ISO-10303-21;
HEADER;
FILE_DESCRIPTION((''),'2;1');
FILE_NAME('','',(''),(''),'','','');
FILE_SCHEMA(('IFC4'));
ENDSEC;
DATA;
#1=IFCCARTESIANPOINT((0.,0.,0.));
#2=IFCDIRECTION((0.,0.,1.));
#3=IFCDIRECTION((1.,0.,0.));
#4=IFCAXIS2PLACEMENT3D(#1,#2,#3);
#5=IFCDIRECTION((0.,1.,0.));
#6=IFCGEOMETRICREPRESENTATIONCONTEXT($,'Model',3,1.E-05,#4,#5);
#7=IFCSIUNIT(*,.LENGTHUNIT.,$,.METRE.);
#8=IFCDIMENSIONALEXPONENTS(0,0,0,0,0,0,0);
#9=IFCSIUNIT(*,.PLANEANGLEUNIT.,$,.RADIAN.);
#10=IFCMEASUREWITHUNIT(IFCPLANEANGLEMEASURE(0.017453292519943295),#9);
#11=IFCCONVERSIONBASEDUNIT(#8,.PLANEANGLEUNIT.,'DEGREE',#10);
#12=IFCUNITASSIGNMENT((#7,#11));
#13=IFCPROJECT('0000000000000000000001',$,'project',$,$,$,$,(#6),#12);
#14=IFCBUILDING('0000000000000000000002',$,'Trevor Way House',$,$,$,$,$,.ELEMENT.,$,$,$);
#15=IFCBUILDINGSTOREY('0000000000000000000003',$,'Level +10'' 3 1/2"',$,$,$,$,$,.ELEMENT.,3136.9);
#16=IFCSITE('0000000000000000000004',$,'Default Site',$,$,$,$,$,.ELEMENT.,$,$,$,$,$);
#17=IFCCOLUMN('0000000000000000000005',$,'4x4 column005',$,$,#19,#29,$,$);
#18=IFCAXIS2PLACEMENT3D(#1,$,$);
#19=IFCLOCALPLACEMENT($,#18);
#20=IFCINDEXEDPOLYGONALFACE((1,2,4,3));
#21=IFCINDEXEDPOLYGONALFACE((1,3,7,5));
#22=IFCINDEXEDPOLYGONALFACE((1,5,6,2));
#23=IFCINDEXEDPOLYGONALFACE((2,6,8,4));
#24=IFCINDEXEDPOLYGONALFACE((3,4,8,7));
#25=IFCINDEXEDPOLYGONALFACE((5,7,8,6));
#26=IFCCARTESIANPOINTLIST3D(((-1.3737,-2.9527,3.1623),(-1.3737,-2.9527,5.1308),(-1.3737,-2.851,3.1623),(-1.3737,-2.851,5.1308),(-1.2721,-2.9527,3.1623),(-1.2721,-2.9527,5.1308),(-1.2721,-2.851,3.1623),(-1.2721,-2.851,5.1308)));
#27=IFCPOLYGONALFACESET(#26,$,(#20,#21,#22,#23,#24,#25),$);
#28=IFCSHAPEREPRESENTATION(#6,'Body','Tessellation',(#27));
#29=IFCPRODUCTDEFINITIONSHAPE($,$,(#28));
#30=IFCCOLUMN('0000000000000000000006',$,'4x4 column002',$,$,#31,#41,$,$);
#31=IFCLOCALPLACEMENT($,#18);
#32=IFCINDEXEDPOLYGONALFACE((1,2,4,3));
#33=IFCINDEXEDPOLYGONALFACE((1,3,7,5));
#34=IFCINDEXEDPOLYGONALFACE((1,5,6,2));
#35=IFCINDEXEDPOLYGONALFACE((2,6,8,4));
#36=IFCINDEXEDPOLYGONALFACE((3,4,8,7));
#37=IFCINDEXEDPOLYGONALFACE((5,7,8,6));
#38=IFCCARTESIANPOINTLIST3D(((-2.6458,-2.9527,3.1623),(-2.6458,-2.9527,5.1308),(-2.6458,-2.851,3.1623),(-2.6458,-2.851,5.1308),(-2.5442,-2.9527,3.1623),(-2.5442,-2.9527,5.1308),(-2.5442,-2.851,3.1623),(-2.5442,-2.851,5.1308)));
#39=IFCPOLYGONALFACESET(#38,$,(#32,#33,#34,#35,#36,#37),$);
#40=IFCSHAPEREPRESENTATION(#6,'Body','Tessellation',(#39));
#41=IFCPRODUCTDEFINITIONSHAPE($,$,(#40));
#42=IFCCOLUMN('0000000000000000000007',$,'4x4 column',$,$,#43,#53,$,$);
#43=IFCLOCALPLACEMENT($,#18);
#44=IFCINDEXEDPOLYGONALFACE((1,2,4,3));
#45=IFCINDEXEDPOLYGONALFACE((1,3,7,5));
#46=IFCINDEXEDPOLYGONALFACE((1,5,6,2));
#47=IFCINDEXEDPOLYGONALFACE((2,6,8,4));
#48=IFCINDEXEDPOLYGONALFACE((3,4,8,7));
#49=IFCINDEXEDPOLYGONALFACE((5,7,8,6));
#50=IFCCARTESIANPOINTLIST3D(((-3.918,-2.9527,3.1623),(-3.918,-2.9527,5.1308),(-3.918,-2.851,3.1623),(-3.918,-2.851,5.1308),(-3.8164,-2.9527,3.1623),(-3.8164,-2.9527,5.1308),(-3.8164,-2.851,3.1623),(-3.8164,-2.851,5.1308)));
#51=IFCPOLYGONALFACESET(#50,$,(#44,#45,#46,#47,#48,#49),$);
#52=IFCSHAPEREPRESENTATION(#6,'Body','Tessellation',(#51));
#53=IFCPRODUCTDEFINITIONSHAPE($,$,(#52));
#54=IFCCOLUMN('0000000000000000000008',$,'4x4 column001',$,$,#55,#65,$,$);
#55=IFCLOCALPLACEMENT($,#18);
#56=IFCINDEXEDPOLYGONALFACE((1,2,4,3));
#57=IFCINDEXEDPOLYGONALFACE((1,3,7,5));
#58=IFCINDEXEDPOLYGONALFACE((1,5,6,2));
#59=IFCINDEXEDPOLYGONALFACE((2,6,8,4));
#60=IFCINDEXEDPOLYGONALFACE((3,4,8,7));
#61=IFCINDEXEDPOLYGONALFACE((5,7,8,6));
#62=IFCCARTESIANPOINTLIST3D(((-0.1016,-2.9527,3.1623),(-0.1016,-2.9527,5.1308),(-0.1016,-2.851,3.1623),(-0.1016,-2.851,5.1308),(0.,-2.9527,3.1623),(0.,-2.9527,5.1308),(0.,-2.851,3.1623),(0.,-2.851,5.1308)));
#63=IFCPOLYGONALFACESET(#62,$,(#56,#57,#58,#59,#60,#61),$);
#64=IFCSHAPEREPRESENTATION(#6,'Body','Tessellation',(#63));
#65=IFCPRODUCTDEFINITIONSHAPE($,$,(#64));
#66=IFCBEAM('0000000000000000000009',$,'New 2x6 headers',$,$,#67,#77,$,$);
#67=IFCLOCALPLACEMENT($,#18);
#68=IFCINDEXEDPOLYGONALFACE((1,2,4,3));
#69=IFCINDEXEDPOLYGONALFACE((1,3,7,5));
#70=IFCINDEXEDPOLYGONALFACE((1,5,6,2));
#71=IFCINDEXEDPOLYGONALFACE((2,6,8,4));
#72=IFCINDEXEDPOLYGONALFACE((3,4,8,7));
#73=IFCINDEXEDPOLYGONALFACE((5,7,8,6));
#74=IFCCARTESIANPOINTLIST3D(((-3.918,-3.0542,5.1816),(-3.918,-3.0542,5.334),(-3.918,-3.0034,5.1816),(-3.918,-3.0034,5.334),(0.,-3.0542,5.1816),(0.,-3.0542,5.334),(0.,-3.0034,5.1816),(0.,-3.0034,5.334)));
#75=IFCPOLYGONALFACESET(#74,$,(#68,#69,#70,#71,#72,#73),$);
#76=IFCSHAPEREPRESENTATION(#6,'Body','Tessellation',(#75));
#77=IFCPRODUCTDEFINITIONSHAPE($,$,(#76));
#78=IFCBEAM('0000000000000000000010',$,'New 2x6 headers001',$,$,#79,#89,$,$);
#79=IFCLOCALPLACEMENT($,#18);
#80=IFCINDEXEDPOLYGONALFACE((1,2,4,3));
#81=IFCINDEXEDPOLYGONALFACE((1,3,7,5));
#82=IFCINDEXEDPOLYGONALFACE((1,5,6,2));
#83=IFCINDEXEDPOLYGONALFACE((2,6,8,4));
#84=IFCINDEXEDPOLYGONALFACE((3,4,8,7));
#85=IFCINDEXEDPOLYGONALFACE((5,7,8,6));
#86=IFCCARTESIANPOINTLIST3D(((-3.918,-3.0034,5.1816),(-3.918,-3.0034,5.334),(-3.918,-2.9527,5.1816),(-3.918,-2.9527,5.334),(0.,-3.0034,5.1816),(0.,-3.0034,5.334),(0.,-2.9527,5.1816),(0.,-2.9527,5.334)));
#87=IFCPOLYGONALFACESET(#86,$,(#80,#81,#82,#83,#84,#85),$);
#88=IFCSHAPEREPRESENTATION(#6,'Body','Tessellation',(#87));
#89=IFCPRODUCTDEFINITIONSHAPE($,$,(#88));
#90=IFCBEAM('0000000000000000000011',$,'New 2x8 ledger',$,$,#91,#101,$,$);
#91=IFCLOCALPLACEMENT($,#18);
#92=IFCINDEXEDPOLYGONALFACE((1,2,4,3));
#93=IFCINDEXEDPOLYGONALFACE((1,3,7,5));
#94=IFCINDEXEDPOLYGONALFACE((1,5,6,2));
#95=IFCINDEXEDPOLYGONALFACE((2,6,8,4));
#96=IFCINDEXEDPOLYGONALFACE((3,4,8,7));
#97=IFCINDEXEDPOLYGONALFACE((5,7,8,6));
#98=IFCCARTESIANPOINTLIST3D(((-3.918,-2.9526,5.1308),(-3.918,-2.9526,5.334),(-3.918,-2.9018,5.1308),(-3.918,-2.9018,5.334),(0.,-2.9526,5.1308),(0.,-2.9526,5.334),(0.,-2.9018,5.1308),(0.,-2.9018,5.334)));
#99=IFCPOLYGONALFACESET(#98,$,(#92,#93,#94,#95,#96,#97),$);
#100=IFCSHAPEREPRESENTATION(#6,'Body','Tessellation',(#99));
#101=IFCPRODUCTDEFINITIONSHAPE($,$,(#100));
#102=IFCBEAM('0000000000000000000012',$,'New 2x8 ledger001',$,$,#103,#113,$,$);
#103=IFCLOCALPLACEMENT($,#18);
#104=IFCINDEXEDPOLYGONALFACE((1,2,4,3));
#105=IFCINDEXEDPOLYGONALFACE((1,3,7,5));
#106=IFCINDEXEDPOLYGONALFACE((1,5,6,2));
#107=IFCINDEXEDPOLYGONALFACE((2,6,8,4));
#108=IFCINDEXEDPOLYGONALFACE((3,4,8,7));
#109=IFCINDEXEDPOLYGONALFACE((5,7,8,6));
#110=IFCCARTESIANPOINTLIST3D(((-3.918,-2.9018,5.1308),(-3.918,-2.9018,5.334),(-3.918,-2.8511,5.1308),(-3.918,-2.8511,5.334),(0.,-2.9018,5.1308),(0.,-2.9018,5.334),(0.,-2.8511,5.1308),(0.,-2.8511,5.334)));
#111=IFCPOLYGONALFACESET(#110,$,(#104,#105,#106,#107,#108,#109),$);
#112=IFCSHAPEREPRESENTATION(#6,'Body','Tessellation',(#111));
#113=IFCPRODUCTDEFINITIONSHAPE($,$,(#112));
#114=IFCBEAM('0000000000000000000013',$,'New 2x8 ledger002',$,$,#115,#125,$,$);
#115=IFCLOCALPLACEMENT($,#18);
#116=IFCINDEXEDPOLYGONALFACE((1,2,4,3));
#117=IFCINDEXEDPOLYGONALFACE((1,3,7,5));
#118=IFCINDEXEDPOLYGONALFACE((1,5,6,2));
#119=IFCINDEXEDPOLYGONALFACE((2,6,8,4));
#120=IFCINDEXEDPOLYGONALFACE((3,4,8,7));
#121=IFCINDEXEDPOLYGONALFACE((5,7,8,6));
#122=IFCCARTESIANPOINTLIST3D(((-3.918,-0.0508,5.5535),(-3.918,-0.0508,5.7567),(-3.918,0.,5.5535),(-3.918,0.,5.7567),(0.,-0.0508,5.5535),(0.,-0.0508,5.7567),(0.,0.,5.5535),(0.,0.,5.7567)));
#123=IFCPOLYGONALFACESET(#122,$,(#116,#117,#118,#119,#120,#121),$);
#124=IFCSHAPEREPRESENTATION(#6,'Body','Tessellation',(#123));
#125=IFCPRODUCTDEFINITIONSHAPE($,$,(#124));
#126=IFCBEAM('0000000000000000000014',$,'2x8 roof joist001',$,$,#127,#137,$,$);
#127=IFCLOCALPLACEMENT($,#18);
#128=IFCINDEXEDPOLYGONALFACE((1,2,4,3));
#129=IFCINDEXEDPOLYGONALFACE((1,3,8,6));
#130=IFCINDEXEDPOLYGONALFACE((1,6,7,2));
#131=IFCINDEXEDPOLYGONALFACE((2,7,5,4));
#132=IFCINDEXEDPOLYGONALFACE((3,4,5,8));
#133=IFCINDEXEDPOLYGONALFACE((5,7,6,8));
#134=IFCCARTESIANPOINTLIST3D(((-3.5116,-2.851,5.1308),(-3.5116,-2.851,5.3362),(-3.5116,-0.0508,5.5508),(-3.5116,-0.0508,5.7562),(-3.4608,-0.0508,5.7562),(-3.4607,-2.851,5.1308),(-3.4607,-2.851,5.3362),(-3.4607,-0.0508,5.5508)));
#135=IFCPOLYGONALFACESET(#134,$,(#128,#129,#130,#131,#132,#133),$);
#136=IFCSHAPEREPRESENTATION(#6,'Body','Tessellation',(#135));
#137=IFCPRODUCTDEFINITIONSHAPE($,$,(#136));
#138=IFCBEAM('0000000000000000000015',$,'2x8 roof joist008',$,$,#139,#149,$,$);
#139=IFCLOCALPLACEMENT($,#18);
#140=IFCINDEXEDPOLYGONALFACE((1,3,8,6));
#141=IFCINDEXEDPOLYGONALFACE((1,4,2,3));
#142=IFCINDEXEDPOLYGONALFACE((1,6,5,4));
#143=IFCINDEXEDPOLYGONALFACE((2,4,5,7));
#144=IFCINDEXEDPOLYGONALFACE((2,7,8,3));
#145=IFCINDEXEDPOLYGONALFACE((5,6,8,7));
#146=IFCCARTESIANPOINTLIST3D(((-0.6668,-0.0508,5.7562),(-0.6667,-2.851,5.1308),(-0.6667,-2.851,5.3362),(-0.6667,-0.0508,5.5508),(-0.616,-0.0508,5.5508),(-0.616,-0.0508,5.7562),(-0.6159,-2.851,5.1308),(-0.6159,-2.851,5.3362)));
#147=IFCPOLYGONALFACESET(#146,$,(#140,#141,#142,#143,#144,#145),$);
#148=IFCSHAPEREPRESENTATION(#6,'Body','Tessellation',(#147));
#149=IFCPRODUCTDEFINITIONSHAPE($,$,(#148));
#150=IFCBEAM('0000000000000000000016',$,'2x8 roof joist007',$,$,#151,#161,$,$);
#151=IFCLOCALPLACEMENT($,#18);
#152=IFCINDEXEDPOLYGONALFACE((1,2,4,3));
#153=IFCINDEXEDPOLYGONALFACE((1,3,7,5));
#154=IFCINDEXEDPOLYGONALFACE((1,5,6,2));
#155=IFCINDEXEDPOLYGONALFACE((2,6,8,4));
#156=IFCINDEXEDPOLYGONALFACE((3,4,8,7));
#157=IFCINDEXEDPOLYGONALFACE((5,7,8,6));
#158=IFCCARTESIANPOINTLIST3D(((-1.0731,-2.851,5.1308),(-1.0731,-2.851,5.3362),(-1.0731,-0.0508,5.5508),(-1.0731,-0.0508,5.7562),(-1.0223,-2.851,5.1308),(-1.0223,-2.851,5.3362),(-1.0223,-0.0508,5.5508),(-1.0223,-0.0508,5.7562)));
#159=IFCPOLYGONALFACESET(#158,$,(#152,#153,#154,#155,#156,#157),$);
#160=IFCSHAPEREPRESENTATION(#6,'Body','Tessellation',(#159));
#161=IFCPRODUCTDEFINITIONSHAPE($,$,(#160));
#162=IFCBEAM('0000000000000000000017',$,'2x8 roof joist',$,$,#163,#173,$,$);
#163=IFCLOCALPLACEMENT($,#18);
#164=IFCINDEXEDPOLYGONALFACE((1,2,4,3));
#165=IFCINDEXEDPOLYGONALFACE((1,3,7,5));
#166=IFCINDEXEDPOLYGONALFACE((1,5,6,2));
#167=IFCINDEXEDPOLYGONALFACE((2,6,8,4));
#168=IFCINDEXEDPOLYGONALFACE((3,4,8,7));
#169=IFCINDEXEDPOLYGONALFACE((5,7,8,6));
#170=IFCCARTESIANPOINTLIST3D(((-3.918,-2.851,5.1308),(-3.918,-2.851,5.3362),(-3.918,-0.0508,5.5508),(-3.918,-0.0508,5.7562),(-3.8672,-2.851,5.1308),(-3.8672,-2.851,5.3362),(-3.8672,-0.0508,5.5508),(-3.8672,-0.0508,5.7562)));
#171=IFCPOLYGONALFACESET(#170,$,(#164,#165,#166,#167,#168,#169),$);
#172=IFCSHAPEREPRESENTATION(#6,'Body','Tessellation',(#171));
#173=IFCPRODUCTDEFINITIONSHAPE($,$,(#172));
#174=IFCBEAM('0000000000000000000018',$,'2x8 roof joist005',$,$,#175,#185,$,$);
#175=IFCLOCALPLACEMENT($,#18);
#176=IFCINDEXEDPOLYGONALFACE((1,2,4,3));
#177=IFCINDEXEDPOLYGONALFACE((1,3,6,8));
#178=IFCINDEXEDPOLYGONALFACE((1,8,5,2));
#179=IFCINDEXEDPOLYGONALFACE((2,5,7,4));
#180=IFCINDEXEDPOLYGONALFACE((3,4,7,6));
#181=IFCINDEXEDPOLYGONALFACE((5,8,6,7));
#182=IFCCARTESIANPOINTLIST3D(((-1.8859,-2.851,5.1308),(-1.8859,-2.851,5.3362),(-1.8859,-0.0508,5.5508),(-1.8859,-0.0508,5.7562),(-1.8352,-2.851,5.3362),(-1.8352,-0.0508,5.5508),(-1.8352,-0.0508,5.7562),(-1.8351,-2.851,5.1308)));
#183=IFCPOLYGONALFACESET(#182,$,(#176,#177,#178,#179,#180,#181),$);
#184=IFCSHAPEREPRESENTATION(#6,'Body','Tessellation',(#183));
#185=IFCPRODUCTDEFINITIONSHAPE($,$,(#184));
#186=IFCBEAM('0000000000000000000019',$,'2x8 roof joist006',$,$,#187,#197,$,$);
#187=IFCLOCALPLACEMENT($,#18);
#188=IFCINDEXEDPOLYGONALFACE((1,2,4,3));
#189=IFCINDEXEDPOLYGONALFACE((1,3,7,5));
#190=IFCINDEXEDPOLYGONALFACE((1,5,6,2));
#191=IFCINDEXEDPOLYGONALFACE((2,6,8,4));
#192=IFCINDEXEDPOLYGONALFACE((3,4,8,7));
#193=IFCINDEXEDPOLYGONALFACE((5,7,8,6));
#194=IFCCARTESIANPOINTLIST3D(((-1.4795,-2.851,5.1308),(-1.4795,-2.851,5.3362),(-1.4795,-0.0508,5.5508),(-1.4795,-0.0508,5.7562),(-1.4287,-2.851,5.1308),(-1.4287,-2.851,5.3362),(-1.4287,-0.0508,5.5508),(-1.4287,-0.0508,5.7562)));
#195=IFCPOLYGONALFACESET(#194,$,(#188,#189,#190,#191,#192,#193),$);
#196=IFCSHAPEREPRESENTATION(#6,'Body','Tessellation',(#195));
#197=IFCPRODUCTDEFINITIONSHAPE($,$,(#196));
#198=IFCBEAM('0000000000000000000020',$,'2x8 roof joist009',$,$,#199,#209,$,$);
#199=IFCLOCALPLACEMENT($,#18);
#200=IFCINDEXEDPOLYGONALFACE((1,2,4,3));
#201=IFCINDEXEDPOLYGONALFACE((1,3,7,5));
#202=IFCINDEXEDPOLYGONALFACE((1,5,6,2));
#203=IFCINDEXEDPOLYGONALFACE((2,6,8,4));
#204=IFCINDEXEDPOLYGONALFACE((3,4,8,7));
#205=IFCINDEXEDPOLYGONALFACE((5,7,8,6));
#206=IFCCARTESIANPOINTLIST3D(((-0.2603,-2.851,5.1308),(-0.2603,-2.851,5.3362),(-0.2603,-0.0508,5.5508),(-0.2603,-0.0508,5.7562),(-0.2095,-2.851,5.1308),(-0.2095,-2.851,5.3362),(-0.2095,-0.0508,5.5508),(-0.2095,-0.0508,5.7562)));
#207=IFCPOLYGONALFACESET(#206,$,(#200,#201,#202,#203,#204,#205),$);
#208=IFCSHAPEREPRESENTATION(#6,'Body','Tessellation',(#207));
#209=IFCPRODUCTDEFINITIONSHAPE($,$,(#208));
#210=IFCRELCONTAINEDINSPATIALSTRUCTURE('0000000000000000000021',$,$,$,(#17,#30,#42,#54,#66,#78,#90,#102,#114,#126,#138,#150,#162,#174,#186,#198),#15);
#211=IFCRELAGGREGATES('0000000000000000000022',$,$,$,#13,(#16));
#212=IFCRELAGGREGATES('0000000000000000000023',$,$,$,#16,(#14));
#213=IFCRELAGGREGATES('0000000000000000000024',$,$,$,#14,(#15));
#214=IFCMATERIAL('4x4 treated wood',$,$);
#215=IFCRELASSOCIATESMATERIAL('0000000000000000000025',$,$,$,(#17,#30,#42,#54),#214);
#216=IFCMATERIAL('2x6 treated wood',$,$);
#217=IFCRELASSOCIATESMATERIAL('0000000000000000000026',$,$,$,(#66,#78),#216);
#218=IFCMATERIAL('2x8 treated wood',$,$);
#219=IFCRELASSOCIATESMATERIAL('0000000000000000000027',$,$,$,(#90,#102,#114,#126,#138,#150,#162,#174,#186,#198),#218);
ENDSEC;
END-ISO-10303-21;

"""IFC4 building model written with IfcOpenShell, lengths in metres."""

from ifc_helpers import new_model, entity, si_unit, converted_unit, direction, frame, origin_with_axes, place, context, project, spatial, polyline, outline, extrude, source, transform, mapped, material, element, save


model = new_model("IFC4")

# Units and contexts
model_context = context("Model", 3, precision=1e-05, world=origin_with_axes(), true_north=direction((0.0, 1.0, 0.0)))
ifc_project = project(units=[si_unit("LENGTHUNIT", "METRE"), converted_unit("PLANEANGLEUNIT", "DEGREE", entity("IfcPlaneAngleMeasure", 0.017453292519943295), si_unit("PLANEANGLEUNIT", "RADIAN"), dimensions=[0, 0, 0, 0, 0, 0, 0])], contexts=[model_context])

# Site, building, storey
site = spatial("IfcSite", under=ifc_project, Name="Default Site", CompositionType="ELEMENT")
building = spatial("IfcBuilding", under=site, Name="Trevor Way House", CompositionType="ELEMENT")
storey = spatial("IfcBuildingStorey", under=building, Name="Level +10' 3 1/2\"", CompositionType="ELEMENT", Elevation=3136.9)

# Columns
ifc_material_1 = material(Name="4x4 treated wood")
shared_shape_1 = source(origin_with_axes(), model_context, "Body", "SweptSolid", [
    extrude(outline(polyline([(-0.0508, -0.0508), (0.0508, -0.0508), (0.0508, 0.0508), (-0.0508, 0.0508), (-0.0508, -0.0508)])), frame((0.0, 0.0, 0.0), z_axis=(0.0, 0.0, 1.0), x_axis=(1.0, 0.0, 0.0)), (0.0, 0.0, 1.0), 1.9685),
])
placement = place(None, origin_with_axes())
element("IfcColumn", 1, at=placement, inside=storey, material=ifc_material_1, Name="4x4 column005", context=model_context, shape_type="MappedRepresentation", body=[
    mapped(shared_shape_1, transform((-1.3229, -2.9019, 3.1623), x_axis=(1.0, 0.0, 0.0), y_axis=(0.0, 1.0, 0.0), z_axis=(0.0, 0.0, 1.0), scale=1.0)),
])
element("IfcColumn", 2, at=placement, inside=storey, material=ifc_material_1, Name="4x4 column002", context=model_context, shape_type="MappedRepresentation", body=[
    mapped(shared_shape_1, transform((-2.595, -2.9019, 3.1623), x_axis=(1.0, 0.0, 0.0), y_axis=(0.0, 1.0, 0.0), z_axis=(0.0, 0.0, 1.0), scale=1.0)),
])
element("IfcColumn", 3, at=placement, inside=storey, material=ifc_material_1, Name="4x4 column", context=model_context, shape_type="MappedRepresentation", body=[
    mapped(shared_shape_1, transform((-3.8672, -2.9019, 3.1623), x_axis=(1.0, 0.0, 0.0), y_axis=(0.0, 1.0, 0.0), z_axis=(0.0, 0.0, 1.0), scale=1.0)),
])
element("IfcColumn", 4, at=placement, inside=storey, material=ifc_material_1, Name="4x4 column001", context=model_context, shape_type="MappedRepresentation", body=[
    mapped(shared_shape_1, transform((-0.0508, -2.9019, 3.1623), x_axis=(1.0, 0.0, 0.0), y_axis=(0.0, 1.0, 0.0), z_axis=(0.0, 0.0, 1.0), scale=1.0)),
])

# Beams
ifc_material_2 = material(Name="2x6 treated wood")
shared_shape_2 = source(origin_with_axes(), model_context, "Body", "SweptSolid", [
    extrude(outline(polyline([(-0.0254, -0.0762), (0.0254, -0.0762), (0.0254, 0.0762), (-0.0254, 0.0762), (-0.0254, -0.0762)])), frame((0.0, 0.0, 0.0), z_axis=(0.0, 0.0, 1.0), x_axis=(1.0, 0.0, 0.0)), (0.0, 0.0, 1.0), 3.9179),
])
element("IfcBeam", 5, at=placement, inside=storey, material=ifc_material_2, Name="New 2x6 headers", context=model_context, shape_type="MappedRepresentation", body=[
    mapped(shared_shape_2, transform((-3.9179, -3.0288, 5.2578), x_axis=(0.0, 1.0, 0.0), y_axis=(0.0, 0.0, 1.0), z_axis=(1.0, 0.0, 0.0), scale=1.0)),
])
element("IfcBeam", 6, at=placement, inside=storey, material=ifc_material_2, Name="New 2x6 headers001", context=model_context, shape_type="MappedRepresentation", body=[
    mapped(shared_shape_2, transform((-3.9179, -2.9781, 5.2578), x_axis=(0.0, 1.0, 0.0), y_axis=(0.0, 0.0, 1.0), z_axis=(1.0, 0.0, 0.0), scale=1.0)),
])
ifc_material_3 = material(Name="2x8 treated wood")
shared_shape_3 = source(origin_with_axes(), model_context, "Body", "SweptSolid", [
    extrude(outline(polyline([(-0.0254, -0.1016), (0.0254, -0.1016), (0.0254, 0.1016), (-0.0254, 0.1016), (-0.0254, -0.1016)])), frame((0.0, 0.0, 0.0), z_axis=(0.0, 0.0, 1.0), x_axis=(1.0, 0.0, 0.0)), (0.0, 0.0, -1.0), 3.9179),
])
element("IfcBeam", 7, at=placement, inside=storey, material=ifc_material_3, Name="New 2x8 ledger", context=model_context, shape_type="MappedRepresentation", body=[
    mapped(shared_shape_3, transform((-3.9179, -2.9272, 5.2324), x_axis=(0.0, -1.0, 0.0), y_axis=(0.0, 0.0, 1.0), z_axis=(-1.0, 0.0, 0.0), scale=1.0)),
])
element("IfcBeam", 8, at=placement, inside=storey, material=ifc_material_3, Name="New 2x8 ledger001", context=model_context, shape_type="MappedRepresentation", body=[
    mapped(shared_shape_3, transform((-3.9179, -2.8765, 5.2324), x_axis=(0.0, -1.0, 0.0), y_axis=(0.0, 0.0, 1.0), z_axis=(-1.0, 0.0, 0.0), scale=1.0)),
])
element("IfcBeam", 9, at=placement, inside=storey, material=ifc_material_3, Name="New 2x8 ledger002", context=model_context, shape_type="MappedRepresentation", body=[
    mapped(shared_shape_3, transform((-3.9179, -0.0254, 5.6551), x_axis=(0.0, -1.0, 0.0), y_axis=(0.0, 0.0, 1.0), z_axis=(-1.0, 0.0, 0.0), scale=1.0)),
])
shared_shape_4 = source(origin_with_axes(), model_context, "Body", "SweptSolid", [
    extrude(outline(polyline([(-0.3127, 1.4001), (0.1073, -1.4001), (0.3127, -1.4001), (-0.1073, 1.4001), (-0.3127, 1.4001)])), frame((-3.9179, -1.4509, 5.4435), z_axis=(1.0, 0.0, 0.0), x_axis=(0.0, 0.0, -1.0)), (0.0, 0.0, 1.0), 0.0508),
])
element("IfcBeam", 10, at=placement, inside=storey, material=ifc_material_3, Name="2x8 roof joist001", context=model_context, shape_type="MappedRepresentation", body=[
    mapped(shared_shape_4, transform((0.4064, 0.0, 0.0), x_axis=(1.0, 0.0, 0.0), y_axis=(0.0, 1.0, 0.0), z_axis=(0.0, 0.0, 1.0), scale=1.0)),
])
element("IfcBeam", 11, at=placement, inside=storey, material=ifc_material_3, Name="2x8 roof joist008", context=model_context, shape_type="MappedRepresentation", body=[
    mapped(shared_shape_4, transform((3.2512, 0.0, 0.0), x_axis=(1.0, 0.0, 0.0), y_axis=(0.0, 1.0, 0.0), z_axis=(0.0, 0.0, 1.0), scale=1.0)),
])
element("IfcBeam", 12, at=placement, inside=storey, material=ifc_material_3, Name="2x8 roof joist007", context=model_context, shape_type="MappedRepresentation", body=[
    mapped(shared_shape_4, transform((2.8448, 0.0, 0.0), x_axis=(1.0, 0.0, 0.0), y_axis=(0.0, 1.0, 0.0), z_axis=(0.0, 0.0, 1.0), scale=1.0)),
])
element("IfcBeam", 13, at=placement, inside=storey, material=ifc_material_3, Name="2x8 roof joist", context=model_context, shape_type="MappedRepresentation", body=[
    mapped(shared_shape_4, transform((0.0, 0.0, 0.0), x_axis=(1.0, 0.0, 0.0), y_axis=(0.0, 1.0, 0.0), z_axis=(0.0, 0.0, 1.0), scale=1.0)),
])
element("IfcBeam", 14, at=placement, inside=storey, material=ifc_material_3, Name="2x8 roof joist005", context=model_context, shape_type="MappedRepresentation", body=[
    mapped(shared_shape_4, transform((2.032, 0.0, 0.0), x_axis=(1.0, 0.0, 0.0), y_axis=(0.0, 1.0, 0.0), z_axis=(0.0, 0.0, 1.0), scale=1.0)),
])
element("IfcBeam", 15, at=placement, inside=storey, material=ifc_material_3, Name="2x8 roof joist006", context=model_context, shape_type="MappedRepresentation", body=[
    mapped(shared_shape_4, transform((2.4384, 0.0, 0.0), x_axis=(1.0, 0.0, 0.0), y_axis=(0.0, 1.0, 0.0), z_axis=(0.0, 0.0, 1.0), scale=1.0)),
])
element("IfcBeam", 16, at=placement, inside=storey, material=ifc_material_3, Name="2x8 roof joist009", context=model_context, shape_type="MappedRepresentation", body=[
    mapped(shared_shape_4, transform((3.6576, 0.0, 0.0), x_axis=(1.0, 0.0, 0.0), y_axis=(0.0, 1.0, 0.0), z_axis=(0.0, 0.0, 1.0), scale=1.0)),
])

save(model, "model.ifc")
